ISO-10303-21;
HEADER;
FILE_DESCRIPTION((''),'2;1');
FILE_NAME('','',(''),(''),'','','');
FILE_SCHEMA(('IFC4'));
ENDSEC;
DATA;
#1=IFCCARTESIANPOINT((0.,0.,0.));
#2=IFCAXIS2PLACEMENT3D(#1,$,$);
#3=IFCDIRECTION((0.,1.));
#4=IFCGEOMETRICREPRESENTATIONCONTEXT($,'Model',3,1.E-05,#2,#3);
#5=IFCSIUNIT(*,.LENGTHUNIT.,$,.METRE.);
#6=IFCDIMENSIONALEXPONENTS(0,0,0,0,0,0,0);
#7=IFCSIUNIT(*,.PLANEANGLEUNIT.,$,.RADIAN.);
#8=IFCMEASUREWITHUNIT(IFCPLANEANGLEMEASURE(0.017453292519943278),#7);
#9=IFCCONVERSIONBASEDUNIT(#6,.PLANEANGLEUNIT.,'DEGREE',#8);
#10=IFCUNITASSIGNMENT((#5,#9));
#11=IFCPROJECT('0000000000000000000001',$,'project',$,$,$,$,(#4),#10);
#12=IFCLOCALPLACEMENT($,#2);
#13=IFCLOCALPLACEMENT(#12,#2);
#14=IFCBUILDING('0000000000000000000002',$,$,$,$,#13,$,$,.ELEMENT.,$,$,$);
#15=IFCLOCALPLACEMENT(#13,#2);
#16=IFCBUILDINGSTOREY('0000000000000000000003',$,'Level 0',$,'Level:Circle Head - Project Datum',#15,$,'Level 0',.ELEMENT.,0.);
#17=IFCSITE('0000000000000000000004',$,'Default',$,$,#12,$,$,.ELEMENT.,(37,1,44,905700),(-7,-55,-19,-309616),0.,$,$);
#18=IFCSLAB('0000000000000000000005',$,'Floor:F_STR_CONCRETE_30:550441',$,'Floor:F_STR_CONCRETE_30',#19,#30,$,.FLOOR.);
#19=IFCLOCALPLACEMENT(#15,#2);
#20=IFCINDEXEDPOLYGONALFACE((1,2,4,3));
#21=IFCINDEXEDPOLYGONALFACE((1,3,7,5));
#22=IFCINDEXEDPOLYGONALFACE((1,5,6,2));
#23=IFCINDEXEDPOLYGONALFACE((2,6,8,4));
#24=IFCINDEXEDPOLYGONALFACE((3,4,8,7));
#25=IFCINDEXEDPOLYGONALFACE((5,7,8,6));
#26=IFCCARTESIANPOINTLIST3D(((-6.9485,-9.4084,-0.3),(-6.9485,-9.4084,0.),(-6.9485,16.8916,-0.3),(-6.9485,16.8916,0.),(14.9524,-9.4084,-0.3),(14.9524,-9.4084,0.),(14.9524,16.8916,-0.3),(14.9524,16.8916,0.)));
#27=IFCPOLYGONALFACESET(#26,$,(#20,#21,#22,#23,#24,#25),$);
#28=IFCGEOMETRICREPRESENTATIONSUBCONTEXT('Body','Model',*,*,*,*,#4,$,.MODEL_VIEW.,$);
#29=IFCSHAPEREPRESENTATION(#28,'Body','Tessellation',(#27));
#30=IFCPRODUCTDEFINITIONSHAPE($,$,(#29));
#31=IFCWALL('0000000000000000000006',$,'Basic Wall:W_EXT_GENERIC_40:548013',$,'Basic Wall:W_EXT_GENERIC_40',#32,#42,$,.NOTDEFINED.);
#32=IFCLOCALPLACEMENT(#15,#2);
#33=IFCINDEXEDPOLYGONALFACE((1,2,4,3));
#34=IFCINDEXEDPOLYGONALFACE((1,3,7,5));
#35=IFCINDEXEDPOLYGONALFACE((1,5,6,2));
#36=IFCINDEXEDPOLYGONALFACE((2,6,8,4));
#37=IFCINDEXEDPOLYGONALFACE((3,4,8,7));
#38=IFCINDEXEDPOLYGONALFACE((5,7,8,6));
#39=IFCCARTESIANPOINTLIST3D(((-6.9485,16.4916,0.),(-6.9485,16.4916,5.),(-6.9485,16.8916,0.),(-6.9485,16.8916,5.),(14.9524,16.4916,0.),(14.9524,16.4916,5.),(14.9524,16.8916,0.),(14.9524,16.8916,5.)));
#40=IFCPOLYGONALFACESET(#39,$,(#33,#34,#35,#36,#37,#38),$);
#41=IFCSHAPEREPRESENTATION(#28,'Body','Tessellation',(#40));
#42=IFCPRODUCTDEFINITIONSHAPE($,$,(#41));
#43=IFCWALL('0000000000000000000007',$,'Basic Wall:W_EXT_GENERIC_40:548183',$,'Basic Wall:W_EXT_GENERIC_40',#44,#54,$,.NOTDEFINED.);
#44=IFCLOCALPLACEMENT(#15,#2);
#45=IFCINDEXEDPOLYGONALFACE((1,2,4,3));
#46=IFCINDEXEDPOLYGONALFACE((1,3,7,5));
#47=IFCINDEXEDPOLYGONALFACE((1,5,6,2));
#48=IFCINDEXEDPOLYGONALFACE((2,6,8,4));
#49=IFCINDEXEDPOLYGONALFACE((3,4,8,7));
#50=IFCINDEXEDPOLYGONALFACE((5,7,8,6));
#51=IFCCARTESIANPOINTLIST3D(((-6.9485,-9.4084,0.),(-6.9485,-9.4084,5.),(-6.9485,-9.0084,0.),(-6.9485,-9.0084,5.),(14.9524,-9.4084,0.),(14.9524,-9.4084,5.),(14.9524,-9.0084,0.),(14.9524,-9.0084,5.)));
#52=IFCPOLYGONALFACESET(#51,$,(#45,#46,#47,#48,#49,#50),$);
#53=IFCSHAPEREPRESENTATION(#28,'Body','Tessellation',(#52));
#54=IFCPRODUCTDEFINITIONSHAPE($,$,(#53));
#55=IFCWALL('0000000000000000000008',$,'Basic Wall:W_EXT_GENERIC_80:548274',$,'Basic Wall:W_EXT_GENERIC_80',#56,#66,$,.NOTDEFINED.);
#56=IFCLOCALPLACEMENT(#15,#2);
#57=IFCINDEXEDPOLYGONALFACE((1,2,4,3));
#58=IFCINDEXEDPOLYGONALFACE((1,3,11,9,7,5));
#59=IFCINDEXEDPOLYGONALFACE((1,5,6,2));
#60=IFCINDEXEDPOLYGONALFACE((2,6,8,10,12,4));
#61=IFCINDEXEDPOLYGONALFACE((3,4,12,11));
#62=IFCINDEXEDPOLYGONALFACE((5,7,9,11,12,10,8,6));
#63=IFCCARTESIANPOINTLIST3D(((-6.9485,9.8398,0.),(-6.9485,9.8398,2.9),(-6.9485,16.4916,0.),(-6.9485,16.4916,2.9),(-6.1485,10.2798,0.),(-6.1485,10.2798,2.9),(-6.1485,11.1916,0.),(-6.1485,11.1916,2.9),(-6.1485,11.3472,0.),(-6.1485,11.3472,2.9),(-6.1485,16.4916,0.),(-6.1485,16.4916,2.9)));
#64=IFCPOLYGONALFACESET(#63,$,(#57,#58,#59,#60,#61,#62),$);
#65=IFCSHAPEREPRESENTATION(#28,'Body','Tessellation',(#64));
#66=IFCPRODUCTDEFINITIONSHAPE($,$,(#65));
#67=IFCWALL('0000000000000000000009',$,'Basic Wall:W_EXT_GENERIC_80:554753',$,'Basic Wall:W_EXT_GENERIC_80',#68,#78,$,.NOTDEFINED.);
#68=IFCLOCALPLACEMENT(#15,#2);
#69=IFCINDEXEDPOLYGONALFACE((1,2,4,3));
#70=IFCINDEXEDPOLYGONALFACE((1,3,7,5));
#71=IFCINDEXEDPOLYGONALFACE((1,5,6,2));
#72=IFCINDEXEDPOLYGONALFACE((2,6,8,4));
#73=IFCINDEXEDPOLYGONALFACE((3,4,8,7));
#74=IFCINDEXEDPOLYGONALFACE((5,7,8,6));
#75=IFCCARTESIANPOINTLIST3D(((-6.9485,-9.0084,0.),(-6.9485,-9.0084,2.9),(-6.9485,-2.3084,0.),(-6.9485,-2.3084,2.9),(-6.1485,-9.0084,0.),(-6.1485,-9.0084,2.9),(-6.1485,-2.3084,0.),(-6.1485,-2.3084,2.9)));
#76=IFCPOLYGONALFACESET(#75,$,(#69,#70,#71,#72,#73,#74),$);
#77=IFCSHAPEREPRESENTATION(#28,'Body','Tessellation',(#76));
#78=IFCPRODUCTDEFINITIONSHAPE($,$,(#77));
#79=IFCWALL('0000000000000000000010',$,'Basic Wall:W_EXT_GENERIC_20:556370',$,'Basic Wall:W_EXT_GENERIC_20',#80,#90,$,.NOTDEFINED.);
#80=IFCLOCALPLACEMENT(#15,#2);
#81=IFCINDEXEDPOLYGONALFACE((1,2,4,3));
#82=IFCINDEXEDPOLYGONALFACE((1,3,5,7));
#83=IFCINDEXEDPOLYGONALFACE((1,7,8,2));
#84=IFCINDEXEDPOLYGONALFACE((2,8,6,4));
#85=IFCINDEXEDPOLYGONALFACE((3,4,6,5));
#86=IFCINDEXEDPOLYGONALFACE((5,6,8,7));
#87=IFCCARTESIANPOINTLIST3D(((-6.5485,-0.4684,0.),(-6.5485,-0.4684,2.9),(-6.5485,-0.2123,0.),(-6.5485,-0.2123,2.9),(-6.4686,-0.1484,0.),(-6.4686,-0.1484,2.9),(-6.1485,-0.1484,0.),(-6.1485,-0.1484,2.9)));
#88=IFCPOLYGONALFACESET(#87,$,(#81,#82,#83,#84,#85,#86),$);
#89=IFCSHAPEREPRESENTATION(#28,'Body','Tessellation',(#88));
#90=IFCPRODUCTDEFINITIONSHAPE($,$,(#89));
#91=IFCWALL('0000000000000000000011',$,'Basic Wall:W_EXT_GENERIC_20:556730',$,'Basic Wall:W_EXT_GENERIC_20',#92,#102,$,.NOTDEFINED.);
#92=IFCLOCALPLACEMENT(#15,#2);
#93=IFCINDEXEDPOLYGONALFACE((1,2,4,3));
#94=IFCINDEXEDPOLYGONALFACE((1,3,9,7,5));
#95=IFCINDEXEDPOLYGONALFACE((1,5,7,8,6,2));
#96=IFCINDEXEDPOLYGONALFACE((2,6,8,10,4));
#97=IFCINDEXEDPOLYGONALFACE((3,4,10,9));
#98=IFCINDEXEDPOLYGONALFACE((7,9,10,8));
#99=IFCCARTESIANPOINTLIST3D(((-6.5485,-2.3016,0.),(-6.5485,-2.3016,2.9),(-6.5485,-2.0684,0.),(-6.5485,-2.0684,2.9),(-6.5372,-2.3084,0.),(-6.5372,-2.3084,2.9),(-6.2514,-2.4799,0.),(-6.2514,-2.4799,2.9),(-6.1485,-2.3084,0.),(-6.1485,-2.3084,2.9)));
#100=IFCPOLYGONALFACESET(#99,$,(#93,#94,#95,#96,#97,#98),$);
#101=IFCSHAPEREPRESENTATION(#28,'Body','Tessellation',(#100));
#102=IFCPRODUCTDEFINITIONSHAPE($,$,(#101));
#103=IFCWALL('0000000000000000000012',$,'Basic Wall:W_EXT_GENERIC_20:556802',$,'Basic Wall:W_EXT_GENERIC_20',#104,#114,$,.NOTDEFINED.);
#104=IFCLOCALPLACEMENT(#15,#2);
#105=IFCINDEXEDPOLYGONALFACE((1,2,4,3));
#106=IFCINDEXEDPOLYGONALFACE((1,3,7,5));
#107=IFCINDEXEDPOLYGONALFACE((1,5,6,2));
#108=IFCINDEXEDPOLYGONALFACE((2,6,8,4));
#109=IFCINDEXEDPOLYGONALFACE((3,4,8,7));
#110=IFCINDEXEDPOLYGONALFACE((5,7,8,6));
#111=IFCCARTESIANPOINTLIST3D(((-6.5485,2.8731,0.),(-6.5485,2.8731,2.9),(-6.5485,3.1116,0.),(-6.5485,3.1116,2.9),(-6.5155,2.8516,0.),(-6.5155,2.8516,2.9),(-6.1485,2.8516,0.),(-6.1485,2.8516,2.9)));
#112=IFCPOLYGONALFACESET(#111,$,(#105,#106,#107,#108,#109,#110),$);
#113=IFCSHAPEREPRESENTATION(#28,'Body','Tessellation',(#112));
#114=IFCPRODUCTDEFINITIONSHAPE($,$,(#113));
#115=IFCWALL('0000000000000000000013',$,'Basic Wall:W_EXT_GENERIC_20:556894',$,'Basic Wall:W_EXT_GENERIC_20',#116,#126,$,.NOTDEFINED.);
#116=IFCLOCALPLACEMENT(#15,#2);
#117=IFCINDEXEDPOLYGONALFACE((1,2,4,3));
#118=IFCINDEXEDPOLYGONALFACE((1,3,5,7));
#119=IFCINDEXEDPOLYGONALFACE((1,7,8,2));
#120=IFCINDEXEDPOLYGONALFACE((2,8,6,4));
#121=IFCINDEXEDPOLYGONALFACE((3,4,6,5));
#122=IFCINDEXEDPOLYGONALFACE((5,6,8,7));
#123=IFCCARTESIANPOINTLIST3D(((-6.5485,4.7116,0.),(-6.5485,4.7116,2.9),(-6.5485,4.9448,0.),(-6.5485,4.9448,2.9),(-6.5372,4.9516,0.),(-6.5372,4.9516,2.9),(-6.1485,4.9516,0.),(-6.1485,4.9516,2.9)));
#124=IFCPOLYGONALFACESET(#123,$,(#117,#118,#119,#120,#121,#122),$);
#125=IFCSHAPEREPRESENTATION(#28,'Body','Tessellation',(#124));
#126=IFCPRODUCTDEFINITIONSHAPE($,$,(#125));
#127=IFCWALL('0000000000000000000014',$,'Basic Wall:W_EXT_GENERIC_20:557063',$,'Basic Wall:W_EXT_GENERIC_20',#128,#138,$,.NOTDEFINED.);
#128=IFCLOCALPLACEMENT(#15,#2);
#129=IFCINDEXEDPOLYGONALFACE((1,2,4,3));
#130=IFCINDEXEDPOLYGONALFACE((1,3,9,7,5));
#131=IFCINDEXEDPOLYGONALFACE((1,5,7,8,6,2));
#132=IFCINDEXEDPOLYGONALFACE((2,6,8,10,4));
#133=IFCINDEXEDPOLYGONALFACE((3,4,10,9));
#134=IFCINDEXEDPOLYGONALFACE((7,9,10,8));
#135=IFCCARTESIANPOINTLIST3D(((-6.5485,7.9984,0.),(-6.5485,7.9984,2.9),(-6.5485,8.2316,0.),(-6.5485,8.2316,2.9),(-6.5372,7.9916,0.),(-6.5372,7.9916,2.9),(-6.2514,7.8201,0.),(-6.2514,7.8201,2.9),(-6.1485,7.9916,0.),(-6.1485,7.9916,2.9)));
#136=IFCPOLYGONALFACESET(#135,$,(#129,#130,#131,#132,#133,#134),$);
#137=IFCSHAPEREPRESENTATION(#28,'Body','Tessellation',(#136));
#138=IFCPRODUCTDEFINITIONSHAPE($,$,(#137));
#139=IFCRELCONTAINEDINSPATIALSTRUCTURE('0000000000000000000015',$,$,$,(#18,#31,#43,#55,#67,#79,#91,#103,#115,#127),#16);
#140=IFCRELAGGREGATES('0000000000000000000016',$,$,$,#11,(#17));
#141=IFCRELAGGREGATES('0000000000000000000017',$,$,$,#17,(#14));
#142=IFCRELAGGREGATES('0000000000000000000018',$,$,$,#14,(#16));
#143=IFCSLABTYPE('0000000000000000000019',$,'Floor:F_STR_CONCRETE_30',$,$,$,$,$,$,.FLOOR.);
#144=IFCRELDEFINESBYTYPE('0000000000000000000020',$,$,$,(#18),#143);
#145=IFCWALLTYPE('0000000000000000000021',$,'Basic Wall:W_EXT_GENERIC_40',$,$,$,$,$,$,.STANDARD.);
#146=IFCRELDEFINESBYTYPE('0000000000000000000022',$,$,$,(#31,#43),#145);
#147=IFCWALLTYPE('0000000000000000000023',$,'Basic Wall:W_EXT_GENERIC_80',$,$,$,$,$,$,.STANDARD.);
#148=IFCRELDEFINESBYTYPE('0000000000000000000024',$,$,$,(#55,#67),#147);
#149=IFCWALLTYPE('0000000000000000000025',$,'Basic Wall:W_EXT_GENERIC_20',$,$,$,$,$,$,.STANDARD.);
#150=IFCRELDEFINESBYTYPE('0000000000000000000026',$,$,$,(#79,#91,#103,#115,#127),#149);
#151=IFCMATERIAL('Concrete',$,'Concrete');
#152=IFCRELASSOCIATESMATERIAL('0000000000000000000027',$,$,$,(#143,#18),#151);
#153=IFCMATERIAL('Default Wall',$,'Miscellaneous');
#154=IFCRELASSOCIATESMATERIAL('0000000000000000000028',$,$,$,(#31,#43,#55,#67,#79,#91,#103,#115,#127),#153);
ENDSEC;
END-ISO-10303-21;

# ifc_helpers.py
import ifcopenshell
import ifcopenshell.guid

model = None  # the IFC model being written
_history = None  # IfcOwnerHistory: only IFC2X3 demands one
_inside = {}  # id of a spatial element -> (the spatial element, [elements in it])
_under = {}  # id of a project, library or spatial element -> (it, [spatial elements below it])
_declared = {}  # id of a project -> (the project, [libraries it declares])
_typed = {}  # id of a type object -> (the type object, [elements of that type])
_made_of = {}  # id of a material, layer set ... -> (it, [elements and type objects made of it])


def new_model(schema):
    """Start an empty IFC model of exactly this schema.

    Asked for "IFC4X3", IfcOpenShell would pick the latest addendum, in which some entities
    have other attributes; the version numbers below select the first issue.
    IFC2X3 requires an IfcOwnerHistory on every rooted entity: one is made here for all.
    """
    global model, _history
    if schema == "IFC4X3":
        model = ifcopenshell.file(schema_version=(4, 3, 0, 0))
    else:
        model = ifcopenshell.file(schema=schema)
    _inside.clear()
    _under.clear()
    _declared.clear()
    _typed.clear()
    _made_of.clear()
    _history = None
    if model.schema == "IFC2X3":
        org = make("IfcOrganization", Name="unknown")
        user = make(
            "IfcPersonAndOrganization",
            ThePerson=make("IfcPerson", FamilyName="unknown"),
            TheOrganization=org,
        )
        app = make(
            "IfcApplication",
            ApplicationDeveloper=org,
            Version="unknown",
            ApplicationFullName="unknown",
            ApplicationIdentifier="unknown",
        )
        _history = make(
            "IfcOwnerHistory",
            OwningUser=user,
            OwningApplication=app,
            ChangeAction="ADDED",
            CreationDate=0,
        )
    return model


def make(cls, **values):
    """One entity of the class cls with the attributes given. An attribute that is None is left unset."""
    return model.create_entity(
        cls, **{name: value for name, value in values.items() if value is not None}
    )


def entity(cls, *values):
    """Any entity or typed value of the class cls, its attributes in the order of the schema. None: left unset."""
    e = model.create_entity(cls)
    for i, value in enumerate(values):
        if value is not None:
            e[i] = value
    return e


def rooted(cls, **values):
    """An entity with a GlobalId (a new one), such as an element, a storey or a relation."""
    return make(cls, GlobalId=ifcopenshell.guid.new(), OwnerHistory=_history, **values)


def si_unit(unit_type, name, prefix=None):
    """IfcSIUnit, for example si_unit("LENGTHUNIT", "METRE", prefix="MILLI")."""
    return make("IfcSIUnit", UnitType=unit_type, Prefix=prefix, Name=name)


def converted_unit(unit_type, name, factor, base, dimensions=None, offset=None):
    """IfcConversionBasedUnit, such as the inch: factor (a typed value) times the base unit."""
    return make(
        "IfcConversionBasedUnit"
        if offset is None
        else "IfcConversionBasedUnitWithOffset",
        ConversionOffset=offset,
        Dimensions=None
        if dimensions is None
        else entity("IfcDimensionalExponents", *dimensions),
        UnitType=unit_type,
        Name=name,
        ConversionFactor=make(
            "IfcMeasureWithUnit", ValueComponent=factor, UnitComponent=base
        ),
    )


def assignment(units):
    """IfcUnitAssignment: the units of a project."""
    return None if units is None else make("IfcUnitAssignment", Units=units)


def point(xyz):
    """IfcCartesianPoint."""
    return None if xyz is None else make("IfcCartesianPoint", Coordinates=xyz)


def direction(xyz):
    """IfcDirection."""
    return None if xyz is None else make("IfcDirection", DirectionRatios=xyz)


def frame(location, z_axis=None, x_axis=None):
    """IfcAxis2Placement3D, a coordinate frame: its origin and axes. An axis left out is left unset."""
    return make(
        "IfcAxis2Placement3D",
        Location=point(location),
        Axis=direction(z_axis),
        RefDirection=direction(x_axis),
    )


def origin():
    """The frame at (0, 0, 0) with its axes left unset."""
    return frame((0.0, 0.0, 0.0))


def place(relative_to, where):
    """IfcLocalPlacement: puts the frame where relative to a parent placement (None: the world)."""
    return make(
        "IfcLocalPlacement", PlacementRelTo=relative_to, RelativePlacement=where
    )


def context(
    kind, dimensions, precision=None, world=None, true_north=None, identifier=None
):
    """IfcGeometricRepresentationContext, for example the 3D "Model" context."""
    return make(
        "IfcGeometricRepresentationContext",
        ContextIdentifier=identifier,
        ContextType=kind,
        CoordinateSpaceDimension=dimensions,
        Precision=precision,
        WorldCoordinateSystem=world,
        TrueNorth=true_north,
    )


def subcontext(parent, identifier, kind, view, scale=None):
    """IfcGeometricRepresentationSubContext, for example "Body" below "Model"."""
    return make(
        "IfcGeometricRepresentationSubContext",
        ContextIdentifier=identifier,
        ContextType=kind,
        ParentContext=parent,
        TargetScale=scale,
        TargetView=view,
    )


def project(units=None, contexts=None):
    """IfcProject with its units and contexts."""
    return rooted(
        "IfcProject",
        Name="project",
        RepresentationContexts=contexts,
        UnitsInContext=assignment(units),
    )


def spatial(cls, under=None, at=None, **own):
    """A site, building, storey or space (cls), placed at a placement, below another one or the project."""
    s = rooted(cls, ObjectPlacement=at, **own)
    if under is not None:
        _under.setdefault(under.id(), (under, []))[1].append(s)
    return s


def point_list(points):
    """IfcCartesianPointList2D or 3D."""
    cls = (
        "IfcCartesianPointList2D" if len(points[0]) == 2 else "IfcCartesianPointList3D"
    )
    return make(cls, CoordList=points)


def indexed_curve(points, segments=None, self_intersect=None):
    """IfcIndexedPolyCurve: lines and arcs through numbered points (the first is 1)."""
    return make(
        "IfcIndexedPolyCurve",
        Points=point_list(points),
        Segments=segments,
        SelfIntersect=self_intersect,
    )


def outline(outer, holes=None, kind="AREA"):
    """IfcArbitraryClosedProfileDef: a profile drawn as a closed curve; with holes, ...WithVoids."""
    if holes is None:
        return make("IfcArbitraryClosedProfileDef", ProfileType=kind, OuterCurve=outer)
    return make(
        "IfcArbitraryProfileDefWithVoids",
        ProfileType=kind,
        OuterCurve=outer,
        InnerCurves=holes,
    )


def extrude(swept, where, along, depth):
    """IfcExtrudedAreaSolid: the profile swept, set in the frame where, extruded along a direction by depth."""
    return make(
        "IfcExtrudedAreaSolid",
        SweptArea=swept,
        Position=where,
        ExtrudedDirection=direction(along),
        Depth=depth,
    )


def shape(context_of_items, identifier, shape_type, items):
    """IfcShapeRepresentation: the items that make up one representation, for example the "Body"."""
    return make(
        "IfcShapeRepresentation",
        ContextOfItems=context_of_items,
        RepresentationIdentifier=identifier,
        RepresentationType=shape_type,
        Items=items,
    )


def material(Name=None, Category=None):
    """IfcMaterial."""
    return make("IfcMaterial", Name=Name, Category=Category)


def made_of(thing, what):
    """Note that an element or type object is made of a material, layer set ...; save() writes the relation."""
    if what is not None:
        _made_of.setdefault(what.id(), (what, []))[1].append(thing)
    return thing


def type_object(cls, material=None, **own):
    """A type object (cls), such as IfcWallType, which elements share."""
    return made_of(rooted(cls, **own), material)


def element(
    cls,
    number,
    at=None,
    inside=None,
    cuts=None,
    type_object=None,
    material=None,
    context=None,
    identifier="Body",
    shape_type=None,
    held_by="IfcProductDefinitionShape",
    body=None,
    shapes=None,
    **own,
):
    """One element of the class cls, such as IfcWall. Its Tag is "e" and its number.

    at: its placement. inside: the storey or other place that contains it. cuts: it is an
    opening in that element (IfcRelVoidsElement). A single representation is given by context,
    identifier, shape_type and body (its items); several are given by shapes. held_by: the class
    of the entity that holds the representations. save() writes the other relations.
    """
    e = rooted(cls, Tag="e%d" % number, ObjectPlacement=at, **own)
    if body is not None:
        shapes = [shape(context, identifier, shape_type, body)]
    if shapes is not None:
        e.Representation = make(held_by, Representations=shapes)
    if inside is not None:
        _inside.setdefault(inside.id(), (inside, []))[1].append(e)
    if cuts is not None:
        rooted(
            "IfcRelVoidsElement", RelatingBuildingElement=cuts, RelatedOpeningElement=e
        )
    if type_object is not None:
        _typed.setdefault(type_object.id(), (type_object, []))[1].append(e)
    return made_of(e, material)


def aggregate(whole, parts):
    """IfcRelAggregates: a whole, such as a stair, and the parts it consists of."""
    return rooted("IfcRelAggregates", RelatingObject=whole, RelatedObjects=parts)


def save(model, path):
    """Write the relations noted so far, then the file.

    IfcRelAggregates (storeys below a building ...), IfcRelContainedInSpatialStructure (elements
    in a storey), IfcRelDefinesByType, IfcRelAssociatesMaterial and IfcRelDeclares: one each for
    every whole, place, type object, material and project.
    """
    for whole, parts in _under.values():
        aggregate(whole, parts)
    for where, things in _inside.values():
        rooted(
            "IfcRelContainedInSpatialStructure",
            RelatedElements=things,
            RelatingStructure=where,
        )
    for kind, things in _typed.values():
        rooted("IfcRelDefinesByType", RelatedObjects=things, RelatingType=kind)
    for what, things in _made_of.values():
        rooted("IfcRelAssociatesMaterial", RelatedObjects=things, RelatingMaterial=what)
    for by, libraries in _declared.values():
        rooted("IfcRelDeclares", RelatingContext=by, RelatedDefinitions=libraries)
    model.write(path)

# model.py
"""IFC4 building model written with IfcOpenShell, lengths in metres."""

from ifc_helpers import new_model, entity, si_unit, converted_unit, direction, frame, origin, place, context, subcontext, project, spatial, indexed_curve, outline, extrude, material, type_object, element, save


model = new_model("IFC4")

# Units and contexts
model_context = context("Model", 3, precision=1e-05, world=origin(), true_north=direction((0.0, 1.0)))
body_context = subcontext(model_context, "Body", "Model", "MODEL_VIEW")
ifc_project = project(units=[si_unit("LENGTHUNIT", "METRE"), converted_unit("PLANEANGLEUNIT", "DEGREE", entity("IfcPlaneAngleMeasure", 0.017453292519943278), si_unit("PLANEANGLEUNIT", "RADIAN"), dimensions=[0, 0, 0, 0, 0, 0, 0])], contexts=[model_context])

# Site, building, storey
site_placement = place(None, origin())
site = spatial("IfcSite", under=ifc_project, at=site_placement, Name="Default", CompositionType="ELEMENT", RefLatitude=(37, 1, 44, 905700), RefLongitude=(-7, -55, -19, -309616), RefElevation=0.0)
building_placement = place(site_placement, origin())
building = spatial("IfcBuilding", under=site, at=building_placement, CompositionType="ELEMENT")
storey_placement = place(building_placement, origin())
storey = spatial("IfcBuildingStorey", under=building, at=storey_placement, Name="Level 0", ObjectType="Level:Circle Head - Project Datum", LongName="Level 0", CompositionType="ELEMENT", Elevation=0.0)

# Slab
ifc_material_1 = material(Name="Concrete", Category="Concrete")
slab_type = type_object("IfcSlabType", Name="Floor:F_STR_CONCRETE_30", PredefinedType="FLOOR", material=ifc_material_1)
slab_placement = place(storey_placement, origin())
element("IfcSlab", 1, at=slab_placement, inside=storey, type_object=slab_type, material=ifc_material_1, Name="Floor:F_STR_CONCRETE_30:550441", ObjectType="Floor:F_STR_CONCRETE_30", PredefinedType="FLOOR", context=body_context, shape_type="SweptSolid", body=[
    extrude(outline(indexed_curve([(-13.15, -10.9504), (13.15, -10.9504), (13.15, 10.9504), (-13.15, 10.9504), (-13.15, -10.9504)], self_intersect=False)), frame((4.0019, 3.7416, 0.0), z_axis=(0.0, 0.0, -1.0), x_axis=(0.0, 1.0, 0.0)), (0.0, 0.0, 1.0), 0.3),
])

# Walls
ifc_material_2 = material(Name="Default Wall", Category="Miscellaneous")
wall_type_1 = type_object("IfcWallType", Name="Basic Wall:W_EXT_GENERIC_40", PredefinedType="STANDARD")
wall_1_placement = place(storey_placement, frame((-6.9485, 16.6916, 0.0)))
element("IfcWall", 2, at=wall_1_placement, inside=storey, type_object=wall_type_1, material=ifc_material_2, Name="Basic Wall:W_EXT_GENERIC_40:548013", ObjectType="Basic Wall:W_EXT_GENERIC_40", PredefinedType="NOTDEFINED", context=body_context, shape_type="SweptSolid", body=[
    extrude(outline(indexed_curve([(21.9008, 0.2), (0.0, 0.2), (0.0, -0.2), (21.9008, -0.2), (21.9008, 0.2)], self_intersect=False)), origin(), (0.0, 0.0, 1.0), 5.0),
])
wall_2_placement = place(storey_placement, frame((14.9524, -9.2084, 0.0), z_axis=(0.0, 0.0, 1.0), x_axis=(-1.0, 0.0, 0.0)))
element("IfcWall", 3, at=wall_2_placement, inside=storey, type_object=wall_type_1, material=ifc_material_2, Name="Basic Wall:W_EXT_GENERIC_40:548183", ObjectType="Basic Wall:W_EXT_GENERIC_40", PredefinedType="NOTDEFINED", context=body_context, shape_type="SweptSolid", body=[
    extrude(outline(indexed_curve([(21.9008, 0.2), (0.0, 0.2), (0.0, -0.2), (21.9008, -0.2), (21.9008, 0.2)], self_intersect=False)), origin(), (0.0, 0.0, 1.0), 5.0),
])
wall_type_2 = type_object("IfcWallType", Name="Basic Wall:W_EXT_GENERIC_80", PredefinedType="STANDARD")
wall_3_placement = place(storey_placement, frame((-6.5485, 16.4916, 0.0), z_axis=(0.0, 0.0, 1.0), x_axis=(0.0, -1.0, 0.0)))
element("IfcWall", 4, at=wall_3_placement, inside=storey, type_object=wall_type_2, material=ifc_material_2, Name="Basic Wall:W_EXT_GENERIC_80:548274", ObjectType="Basic Wall:W_EXT_GENERIC_80", PredefinedType="NOTDEFINED", context=body_context, shape_type="SweptSolid", body=[
    extrude(outline(indexed_curve([(6.6517, -0.4), (6.2117, 0.4), (5.3, 0.4), (5.1444, 0.4), (0.0, 0.4), (0.0, -0.4), (6.6517, -0.4)], self_intersect=False)), origin(), (0.0, 0.0, 1.0), 2.9),
])
wall_4_placement = place(storey_placement, frame((-6.5485, -2.3084, 0.0), z_axis=(0.0, 0.0, 1.0), x_axis=(0.0, -1.0, 0.0)))
element("IfcWall", 5, at=wall_4_placement, inside=storey, type_object=wall_type_2, material=ifc_material_2, Name="Basic Wall:W_EXT_GENERIC_80:554753", ObjectType="Basic Wall:W_EXT_GENERIC_80", PredefinedType="NOTDEFINED", context=body_context, shape_type="SweptSolid", body=[
    extrude(outline(indexed_curve([(6.7, 0.4), (0.0, 0.4), (0.0, -0.4), (6.7, -0.4), (6.7, 0.4)], self_intersect=False)), origin(), (0.0, 0.0, 1.0), 2.9),
])
wall_type_3 = type_object("IfcWallType", Name="Basic Wall:W_EXT_GENERIC_20", PredefinedType="STANDARD")
wall_5_placement = place(storey_placement, frame((-6.2109, -0.0703, 0.0), z_axis=(0.0, 0.0, 1.0), x_axis=(-0.780869, -0.624695, 0.0)))
element("IfcWall", 6, at=wall_5_placement, inside=storey, type_object=wall_type_3, material=ifc_material_2, Name="Basic Wall:W_EXT_GENERIC_20:556370", ObjectType="Basic Wall:W_EXT_GENERIC_20", PredefinedType="NOTDEFINED", context=body_context, shape_type="SweptSolid", body=[
    extrude(outline(indexed_curve([(0.0, 0.1), (0.25, -0.1), (0.3522, -0.1), (0.5122, 0.1), (0.0, 0.1)], self_intersect=False)), origin(), (0.0, 0.0, 1.0), 2.9),
])
wall_6_placement = place(storey_placement, frame((-6.1999, -2.3942, 0.0), z_axis=(0.0, 0.0, 1.0), x_axis=(-0.857493, 0.514496, 0.0)))
element("IfcWall", 7, at=wall_6_placement, inside=storey, type_object=wall_type_3, material=ifc_material_2, Name="Basic Wall:W_EXT_GENERIC_20:556730", ObjectType="Basic Wall:W_EXT_GENERIC_20", PredefinedType="NOTDEFINED", context=body_context, shape_type="SweptSolid", body=[
    extrude(outline(indexed_curve([(0.4665, -0.1), (0.3465, 0.1), (0.3333, 0.1), (0.0, 0.1), (0.0, -0.1), (0.4665, -0.1)], self_intersect=False)), origin(), (0.0, 0.0, 1.0), 2.9),
])
wall_7_placement = place(storey_placement, frame((-6.203, 2.7677, 0.0), z_axis=(0.0, 0.0, 1.0), x_axis=(-0.838444, 0.544988, 0.0)))
element("IfcWall", 8, at=wall_7_placement, inside=storey, type_object=wall_type_3, material=ifc_material_2, Name="Basic Wall:W_EXT_GENERIC_20:556802", ObjectType="Basic Wall:W_EXT_GENERIC_20", PredefinedType="NOTDEFINED", context=body_context, shape_type="SweptSolid", body=[
    extrude(outline(indexed_curve([(0.4771, -0.1), (0.3471, 0.1), (0.3077, 0.1), (0.0, -0.1), (0.4771, -0.1)], self_intersect=False)), origin(), (0.0, 0.0, 1.0), 2.9),
])
wall_8_placement = place(storey_placement, frame((-6.1999, 5.0373, 0.0), z_axis=(0.0, 0.0, 1.0), x_axis=(-0.857493, -0.514496, 0.0)))
element("IfcWall", 9, at=wall_8_placement, inside=storey, type_object=wall_type_3, material=ifc_material_2, Name="Basic Wall:W_EXT_GENERIC_20:556894", ObjectType="Basic Wall:W_EXT_GENERIC_20", PredefinedType="NOTDEFINED", context=body_context, shape_type="SweptSolid", body=[
    extrude(outline(indexed_curve([(0.0, 0.1), (0.3333, -0.1), (0.3465, -0.1), (0.4665, 0.1), (0.0, 0.1)], self_intersect=False)), origin(), (0.0, 0.0, 1.0), 2.9),
])
wall_9_placement = place(storey_placement, frame((-6.1999, 7.9058, 0.0), z_axis=(0.0, 0.0, 1.0), x_axis=(-0.857493, 0.514496, 0.0)))
element("IfcWall", 10, at=wall_9_placement, inside=storey, type_object=wall_type_3, material=ifc_material_2, Name="Basic Wall:W_EXT_GENERIC_20:557063", ObjectType="Basic Wall:W_EXT_GENERIC_20", PredefinedType="NOTDEFINED", context=body_context, shape_type="SweptSolid", body=[
    extrude(outline(indexed_curve([(0.4665, -0.1), (0.3465, 0.1), (0.3333, 0.1), (0.0, 0.1), (0.0, -0.1), (0.4665, -0.1)], self_intersect=False)), origin(), (0.0, 0.0, 1.0), 2.9),
])

save(model, "model.ifc")
